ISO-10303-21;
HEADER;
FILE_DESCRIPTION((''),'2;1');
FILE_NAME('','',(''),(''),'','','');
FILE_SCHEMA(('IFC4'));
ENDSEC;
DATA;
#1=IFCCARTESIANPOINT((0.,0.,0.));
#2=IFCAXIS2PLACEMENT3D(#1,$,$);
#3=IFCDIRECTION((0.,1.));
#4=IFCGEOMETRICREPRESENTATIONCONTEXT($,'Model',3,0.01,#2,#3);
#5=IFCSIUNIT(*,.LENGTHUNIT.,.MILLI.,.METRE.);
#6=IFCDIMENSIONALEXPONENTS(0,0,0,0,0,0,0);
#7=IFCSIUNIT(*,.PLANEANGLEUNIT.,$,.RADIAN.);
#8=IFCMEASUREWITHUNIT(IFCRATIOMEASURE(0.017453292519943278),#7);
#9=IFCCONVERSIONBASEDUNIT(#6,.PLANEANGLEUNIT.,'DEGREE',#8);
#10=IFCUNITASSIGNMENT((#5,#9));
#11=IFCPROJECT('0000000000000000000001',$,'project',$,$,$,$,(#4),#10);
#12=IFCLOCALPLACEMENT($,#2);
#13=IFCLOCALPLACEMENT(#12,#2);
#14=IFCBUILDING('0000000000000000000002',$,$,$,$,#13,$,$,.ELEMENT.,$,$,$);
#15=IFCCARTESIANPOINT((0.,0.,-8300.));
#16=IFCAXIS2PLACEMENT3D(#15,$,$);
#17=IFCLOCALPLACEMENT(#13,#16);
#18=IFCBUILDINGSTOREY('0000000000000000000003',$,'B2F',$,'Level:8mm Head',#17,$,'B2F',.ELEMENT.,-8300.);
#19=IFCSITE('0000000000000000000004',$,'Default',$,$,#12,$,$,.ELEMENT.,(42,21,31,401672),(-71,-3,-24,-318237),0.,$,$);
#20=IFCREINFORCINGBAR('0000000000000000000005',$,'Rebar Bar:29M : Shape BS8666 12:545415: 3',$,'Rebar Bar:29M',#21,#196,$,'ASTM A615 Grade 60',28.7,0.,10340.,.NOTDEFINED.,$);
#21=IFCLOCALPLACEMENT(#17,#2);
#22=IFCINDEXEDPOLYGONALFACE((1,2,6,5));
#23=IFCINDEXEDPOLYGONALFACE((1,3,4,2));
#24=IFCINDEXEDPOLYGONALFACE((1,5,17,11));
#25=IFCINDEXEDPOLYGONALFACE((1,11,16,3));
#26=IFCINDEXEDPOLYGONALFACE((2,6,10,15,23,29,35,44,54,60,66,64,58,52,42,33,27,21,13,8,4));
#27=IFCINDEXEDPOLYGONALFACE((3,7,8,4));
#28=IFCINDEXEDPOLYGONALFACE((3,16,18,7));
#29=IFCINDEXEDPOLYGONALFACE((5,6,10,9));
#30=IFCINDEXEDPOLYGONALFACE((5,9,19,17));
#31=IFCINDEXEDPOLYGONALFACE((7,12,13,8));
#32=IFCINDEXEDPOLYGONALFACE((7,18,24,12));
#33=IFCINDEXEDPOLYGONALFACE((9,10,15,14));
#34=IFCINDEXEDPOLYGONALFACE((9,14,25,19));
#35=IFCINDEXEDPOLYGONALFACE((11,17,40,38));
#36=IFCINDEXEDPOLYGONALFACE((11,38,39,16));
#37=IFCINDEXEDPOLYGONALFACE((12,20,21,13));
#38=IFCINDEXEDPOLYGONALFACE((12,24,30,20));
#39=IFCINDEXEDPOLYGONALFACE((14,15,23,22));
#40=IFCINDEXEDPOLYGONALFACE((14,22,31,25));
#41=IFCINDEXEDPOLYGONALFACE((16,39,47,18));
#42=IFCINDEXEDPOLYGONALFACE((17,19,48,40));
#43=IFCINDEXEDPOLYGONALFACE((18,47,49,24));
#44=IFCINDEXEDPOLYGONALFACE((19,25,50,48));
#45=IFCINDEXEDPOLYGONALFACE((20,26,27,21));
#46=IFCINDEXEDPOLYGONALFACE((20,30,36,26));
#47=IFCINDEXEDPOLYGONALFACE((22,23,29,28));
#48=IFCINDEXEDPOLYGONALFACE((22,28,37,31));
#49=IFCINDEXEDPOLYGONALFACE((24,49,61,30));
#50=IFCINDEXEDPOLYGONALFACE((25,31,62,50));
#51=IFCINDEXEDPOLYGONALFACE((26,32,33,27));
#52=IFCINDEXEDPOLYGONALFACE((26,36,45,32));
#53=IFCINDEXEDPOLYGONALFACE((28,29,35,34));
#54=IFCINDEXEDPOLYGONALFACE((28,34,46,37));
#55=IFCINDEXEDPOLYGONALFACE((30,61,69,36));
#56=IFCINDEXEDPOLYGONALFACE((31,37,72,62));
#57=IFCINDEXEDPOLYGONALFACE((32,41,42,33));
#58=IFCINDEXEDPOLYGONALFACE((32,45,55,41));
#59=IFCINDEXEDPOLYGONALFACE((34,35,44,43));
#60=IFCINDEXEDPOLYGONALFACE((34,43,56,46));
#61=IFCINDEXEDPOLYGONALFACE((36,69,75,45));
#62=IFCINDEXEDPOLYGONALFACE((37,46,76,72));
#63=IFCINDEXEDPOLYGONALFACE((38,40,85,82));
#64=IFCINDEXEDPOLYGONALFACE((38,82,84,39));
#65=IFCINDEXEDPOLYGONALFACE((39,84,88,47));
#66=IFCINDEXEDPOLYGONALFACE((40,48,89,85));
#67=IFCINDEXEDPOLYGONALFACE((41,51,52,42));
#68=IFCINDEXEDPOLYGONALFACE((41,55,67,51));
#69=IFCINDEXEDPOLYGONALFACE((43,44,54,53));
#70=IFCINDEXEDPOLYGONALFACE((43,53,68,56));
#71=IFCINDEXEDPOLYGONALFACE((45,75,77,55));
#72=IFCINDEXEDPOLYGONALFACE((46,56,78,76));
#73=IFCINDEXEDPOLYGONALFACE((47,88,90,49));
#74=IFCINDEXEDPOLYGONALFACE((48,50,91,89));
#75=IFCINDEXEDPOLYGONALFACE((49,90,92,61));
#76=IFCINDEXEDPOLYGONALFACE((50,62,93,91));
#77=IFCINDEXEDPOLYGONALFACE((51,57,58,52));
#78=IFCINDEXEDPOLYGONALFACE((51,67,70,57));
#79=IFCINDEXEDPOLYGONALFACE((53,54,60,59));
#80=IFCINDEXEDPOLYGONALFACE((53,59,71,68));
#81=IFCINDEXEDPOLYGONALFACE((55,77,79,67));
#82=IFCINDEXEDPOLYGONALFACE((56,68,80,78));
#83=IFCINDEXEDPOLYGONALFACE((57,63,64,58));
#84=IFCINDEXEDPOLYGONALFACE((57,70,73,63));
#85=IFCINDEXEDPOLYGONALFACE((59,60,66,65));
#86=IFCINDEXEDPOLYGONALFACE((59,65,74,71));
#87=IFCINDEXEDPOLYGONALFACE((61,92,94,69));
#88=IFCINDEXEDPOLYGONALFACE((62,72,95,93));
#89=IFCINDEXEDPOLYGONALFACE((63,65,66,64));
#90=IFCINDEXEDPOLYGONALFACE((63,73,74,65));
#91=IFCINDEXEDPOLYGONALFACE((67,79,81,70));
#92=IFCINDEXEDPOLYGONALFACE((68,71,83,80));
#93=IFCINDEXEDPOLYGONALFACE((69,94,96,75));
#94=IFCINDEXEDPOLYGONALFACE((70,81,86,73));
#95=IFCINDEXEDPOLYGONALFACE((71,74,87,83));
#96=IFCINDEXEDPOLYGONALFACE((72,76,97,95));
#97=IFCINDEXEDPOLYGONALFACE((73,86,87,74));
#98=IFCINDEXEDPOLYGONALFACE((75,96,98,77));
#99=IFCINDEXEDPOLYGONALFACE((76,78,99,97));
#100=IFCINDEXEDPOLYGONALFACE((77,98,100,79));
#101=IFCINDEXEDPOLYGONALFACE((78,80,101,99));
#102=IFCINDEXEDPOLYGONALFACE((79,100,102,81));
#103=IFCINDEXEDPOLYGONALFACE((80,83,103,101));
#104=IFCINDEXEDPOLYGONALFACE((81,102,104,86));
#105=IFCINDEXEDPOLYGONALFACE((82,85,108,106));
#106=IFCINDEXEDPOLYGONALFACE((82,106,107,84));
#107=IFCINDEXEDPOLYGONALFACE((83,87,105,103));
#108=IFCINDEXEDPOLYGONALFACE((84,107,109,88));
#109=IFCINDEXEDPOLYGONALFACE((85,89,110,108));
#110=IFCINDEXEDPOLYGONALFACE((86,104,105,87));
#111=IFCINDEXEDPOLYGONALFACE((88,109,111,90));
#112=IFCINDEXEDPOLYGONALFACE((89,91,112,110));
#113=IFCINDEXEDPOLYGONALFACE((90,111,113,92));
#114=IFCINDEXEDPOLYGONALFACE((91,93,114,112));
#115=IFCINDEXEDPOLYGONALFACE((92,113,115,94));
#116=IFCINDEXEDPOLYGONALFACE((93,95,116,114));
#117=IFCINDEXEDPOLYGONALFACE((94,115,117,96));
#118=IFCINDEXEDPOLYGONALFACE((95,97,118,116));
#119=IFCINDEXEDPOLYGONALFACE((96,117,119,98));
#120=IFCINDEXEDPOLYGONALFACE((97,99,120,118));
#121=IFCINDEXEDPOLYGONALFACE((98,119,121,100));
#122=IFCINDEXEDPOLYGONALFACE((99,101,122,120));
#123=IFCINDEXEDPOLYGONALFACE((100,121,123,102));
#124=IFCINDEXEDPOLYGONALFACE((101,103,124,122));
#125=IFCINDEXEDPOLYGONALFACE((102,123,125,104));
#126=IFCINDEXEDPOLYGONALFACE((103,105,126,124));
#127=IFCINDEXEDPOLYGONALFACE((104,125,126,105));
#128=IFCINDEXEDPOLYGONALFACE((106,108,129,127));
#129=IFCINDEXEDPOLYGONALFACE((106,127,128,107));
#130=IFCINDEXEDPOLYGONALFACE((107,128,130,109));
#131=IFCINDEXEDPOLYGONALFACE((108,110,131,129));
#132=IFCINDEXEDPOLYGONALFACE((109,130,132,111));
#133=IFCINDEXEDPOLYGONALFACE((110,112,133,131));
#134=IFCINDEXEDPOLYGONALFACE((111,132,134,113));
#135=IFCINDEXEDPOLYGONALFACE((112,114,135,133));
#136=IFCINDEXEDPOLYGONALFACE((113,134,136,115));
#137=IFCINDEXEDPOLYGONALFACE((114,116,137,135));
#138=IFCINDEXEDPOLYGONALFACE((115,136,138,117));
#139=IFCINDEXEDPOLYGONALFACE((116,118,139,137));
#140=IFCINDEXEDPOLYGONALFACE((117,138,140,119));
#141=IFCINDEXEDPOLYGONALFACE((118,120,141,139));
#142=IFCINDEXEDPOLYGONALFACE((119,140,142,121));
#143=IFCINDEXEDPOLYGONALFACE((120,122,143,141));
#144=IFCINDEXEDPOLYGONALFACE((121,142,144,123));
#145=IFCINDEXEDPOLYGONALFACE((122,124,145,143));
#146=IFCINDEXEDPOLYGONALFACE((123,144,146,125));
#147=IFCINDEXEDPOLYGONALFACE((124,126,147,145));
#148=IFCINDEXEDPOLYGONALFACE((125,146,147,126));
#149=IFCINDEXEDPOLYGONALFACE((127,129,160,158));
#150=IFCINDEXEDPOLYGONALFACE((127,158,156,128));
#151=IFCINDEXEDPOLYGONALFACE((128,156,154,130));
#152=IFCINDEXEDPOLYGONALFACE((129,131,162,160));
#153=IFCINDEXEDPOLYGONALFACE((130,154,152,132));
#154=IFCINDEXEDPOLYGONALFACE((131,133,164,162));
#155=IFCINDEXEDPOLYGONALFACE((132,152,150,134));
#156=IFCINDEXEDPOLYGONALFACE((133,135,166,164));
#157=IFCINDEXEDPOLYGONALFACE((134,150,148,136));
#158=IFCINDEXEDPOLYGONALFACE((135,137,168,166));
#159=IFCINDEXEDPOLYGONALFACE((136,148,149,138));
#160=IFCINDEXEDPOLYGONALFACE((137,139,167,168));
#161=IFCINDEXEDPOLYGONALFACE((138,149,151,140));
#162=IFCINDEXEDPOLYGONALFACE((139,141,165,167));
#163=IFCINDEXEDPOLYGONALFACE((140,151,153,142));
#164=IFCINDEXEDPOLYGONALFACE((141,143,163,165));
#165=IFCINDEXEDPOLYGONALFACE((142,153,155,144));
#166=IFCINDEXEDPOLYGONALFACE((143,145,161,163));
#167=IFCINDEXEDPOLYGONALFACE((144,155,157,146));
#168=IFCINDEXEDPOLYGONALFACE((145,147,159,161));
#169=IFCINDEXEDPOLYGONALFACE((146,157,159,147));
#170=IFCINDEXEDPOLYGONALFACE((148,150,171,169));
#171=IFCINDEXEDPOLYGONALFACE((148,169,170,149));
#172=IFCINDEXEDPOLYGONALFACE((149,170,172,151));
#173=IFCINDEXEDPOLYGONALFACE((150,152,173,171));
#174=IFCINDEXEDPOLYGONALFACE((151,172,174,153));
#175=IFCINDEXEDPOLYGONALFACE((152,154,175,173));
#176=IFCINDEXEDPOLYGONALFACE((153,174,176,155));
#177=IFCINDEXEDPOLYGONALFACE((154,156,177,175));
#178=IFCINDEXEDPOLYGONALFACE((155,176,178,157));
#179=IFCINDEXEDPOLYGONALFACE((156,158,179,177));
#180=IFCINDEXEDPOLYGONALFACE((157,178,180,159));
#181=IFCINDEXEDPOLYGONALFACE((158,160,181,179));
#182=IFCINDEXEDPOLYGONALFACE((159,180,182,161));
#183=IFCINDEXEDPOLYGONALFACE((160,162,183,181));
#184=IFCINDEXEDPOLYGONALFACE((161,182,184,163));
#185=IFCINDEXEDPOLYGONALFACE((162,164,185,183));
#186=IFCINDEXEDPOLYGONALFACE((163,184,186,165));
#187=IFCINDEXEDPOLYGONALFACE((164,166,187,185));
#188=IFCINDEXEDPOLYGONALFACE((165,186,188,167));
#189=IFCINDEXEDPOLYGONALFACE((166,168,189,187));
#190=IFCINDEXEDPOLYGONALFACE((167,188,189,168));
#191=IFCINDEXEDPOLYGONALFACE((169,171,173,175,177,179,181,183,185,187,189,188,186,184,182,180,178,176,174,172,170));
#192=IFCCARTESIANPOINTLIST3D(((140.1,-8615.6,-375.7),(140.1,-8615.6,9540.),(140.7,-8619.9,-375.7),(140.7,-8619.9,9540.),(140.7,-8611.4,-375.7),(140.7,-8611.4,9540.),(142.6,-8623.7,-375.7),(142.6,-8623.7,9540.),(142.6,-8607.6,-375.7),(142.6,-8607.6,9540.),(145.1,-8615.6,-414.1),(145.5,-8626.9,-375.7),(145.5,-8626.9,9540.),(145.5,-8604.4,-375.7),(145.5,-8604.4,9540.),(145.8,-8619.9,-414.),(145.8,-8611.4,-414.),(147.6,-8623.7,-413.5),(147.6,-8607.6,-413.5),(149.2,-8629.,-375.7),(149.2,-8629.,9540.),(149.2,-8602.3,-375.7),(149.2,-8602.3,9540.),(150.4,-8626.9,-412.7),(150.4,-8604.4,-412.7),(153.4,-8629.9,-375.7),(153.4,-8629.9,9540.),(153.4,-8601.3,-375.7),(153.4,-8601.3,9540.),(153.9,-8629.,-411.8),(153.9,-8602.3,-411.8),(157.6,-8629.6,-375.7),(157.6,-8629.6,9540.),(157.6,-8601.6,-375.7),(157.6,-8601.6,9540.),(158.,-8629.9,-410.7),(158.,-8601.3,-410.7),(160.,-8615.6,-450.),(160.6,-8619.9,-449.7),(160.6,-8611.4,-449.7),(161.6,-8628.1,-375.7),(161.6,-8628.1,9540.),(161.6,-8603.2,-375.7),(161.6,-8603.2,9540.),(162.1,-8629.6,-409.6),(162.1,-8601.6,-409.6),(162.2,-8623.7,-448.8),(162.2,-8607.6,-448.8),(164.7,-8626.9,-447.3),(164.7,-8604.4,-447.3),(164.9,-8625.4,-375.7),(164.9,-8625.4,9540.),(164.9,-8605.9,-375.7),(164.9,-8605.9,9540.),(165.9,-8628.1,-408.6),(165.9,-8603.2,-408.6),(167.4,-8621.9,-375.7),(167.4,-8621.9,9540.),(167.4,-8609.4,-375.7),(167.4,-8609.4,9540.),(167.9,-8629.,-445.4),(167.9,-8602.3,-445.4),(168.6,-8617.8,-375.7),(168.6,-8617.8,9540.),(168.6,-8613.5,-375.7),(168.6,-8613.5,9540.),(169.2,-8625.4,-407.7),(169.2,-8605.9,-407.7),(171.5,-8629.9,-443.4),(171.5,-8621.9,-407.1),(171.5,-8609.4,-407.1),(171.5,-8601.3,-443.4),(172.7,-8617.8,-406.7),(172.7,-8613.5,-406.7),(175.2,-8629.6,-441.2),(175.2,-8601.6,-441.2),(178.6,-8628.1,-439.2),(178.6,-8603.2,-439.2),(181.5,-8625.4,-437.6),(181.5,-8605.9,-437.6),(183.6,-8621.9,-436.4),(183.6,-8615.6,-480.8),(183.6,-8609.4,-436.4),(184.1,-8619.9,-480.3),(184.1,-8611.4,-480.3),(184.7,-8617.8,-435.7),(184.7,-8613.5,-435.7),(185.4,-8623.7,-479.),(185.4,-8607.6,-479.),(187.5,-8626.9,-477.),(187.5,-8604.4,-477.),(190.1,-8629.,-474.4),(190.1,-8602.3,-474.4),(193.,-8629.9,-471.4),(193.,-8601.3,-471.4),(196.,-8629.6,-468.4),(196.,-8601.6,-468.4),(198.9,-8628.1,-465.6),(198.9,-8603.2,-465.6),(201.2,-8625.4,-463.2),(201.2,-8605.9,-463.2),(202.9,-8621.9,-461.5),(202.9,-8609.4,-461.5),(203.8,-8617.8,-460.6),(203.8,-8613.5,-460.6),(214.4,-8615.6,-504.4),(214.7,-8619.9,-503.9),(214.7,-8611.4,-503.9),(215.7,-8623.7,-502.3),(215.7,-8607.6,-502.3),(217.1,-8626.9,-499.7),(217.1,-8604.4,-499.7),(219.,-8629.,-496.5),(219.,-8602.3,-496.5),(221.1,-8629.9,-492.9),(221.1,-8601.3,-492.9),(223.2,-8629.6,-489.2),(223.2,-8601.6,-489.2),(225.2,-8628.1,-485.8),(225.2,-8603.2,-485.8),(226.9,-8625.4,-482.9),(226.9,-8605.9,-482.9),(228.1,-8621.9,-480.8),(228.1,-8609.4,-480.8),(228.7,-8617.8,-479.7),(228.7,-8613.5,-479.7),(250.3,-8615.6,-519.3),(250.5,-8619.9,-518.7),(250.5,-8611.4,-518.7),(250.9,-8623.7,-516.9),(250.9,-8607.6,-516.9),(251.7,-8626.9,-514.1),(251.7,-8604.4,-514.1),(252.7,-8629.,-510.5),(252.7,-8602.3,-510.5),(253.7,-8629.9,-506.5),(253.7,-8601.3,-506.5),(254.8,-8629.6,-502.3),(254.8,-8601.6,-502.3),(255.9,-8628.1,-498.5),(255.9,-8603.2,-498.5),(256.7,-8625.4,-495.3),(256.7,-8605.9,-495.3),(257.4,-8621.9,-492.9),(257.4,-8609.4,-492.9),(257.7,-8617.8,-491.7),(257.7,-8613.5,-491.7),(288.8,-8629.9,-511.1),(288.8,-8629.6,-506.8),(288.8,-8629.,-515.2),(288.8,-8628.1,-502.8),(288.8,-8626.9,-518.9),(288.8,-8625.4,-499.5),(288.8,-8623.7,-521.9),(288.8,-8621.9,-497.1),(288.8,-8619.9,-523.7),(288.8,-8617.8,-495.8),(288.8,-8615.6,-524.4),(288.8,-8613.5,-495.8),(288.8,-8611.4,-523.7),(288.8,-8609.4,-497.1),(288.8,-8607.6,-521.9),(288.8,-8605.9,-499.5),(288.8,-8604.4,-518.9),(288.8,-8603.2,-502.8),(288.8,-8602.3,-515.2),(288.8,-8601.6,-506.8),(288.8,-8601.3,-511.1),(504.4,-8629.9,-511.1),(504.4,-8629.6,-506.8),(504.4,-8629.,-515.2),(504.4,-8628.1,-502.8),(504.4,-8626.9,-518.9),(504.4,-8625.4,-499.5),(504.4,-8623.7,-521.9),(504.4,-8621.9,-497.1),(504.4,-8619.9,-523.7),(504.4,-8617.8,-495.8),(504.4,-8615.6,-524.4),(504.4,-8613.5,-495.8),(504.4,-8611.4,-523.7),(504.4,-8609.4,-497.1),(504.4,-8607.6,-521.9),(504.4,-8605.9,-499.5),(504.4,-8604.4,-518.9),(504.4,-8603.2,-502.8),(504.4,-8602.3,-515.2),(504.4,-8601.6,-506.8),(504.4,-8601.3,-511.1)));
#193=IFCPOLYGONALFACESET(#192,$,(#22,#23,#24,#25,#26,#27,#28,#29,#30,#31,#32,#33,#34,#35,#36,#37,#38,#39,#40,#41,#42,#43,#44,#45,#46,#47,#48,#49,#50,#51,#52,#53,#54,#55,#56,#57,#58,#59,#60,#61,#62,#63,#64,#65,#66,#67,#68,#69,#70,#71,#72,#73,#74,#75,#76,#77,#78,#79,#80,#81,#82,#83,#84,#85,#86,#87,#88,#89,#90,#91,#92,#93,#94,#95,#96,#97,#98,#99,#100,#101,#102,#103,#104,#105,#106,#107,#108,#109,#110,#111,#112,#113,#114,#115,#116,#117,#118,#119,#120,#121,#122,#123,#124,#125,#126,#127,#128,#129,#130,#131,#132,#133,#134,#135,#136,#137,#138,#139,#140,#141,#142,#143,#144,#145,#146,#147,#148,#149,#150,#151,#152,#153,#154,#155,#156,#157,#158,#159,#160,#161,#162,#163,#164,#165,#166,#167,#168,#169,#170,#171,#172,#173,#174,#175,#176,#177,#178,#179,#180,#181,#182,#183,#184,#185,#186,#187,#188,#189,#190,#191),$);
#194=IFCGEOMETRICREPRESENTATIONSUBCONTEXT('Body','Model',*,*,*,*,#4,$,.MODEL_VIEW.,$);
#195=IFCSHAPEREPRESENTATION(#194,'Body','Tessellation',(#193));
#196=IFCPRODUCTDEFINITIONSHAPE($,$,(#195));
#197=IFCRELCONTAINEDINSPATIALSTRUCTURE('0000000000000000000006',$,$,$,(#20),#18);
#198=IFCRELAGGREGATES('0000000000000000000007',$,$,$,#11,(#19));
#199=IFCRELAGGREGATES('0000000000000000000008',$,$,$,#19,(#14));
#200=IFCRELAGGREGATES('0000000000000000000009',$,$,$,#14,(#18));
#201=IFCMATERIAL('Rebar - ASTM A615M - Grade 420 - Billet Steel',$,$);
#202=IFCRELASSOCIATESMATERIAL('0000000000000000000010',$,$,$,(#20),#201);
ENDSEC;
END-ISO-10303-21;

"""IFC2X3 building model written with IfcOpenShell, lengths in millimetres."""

from ifc_helpers import new_model, entity, si_unit, converted_unit, direction, frame, origin, place, context, subcontext, project, spatial, material, element, save


model = new_model("IFC2X3")

# Units and contexts
model_context = context("Model", 3, precision=0.01, world=origin(), true_north=direction((0.0, 1.0)))
body_context = subcontext(model_context, "Body", "Model", "MODEL_VIEW")
ifc_project = project(units=[si_unit("LENGTHUNIT", "METRE", prefix="MILLI"), converted_unit("PLANEANGLEUNIT", "DEGREE", entity("IfcRatioMeasure", 0.017453292519943278), si_unit("PLANEANGLEUNIT", "RADIAN"), dimensions=[0, 0, 0, 0, 0, 0, 0])], contexts=[model_context])

# Site, building, storey
site_placement = place(None, origin())
site = spatial("IfcSite", under=ifc_project, at=site_placement, Name="Default", CompositionType="ELEMENT", RefLatitude=(42, 21, 31, 401672), RefLongitude=(-71, -3, -24, -318237), RefElevation=0.0)
building_placement = place(site_placement, origin())
building = spatial("IfcBuilding", under=site, at=building_placement, CompositionType="ELEMENT")
storey_placement = place(building_placement, frame((0.0, 0.0, -8300.0)))
storey = spatial("IfcBuildingStorey", under=building, at=storey_placement, Name="B2F", ObjectType="Level:8mm Head", LongName="B2F", CompositionType="ELEMENT", Elevation=-8300.0)

# Reinforcing bar
ifc_material_1 = material(Name="Rebar - ASTM A615M - Grade 420 - Billet Steel")
reinforcing_bar_1_placement = place(storey_placement, origin())
element("IfcReinforcingBar", 1, at=reinforcing_bar_1_placement, inside=storey, material=ifc_material_1, Name="Rebar Bar:29M : Shape BS8666 12:545415: 3", SteelGrade="ASTM A615 Grade 60", ObjectType="Rebar Bar:29M", BarLength=10340.0, BarRole="NOTDEFINED", CrossSectionArea=0.0, NominalDiameter=28.7, context=body_context, shape_type="AdvancedSweptSolid", body=[
    entity("IfcSweptDiskSolid", entity("IfcCompositeCurve", [entity("IfcCompositeCurveSegment", "CONTINUOUS", True, entity("IfcPolyline", [entity("IfcCartesianPoint", [154.4, -8615.6, 9540.0]), entity("IfcCartesianPoint", [154.4, -8615.6, -375.7])])), entity("IfcCompositeCurveSegment", "CONTINUOUS", True, entity("IfcTrimmedCurve", entity("IfcCircle", entity("IfcAxis2Placement3D", entity("IfcCartesianPoint", [288.8, -8615.6, -375.7]), entity("IfcDirection", [0.0, -1.0, 0.0]), entity("IfcDirection", [0.0, 0.0, -1.0])), 134.3), [entity("IfcParameterValue", 270.0)], [entity("IfcParameterValue", 360.0)], True, "PARAMETER")), entity("IfcCompositeCurveSegment", "CONTINUOUS", True, entity("IfcPolyline", [entity("IfcCartesianPoint", [288.8, -8615.6, -510.0]), entity("IfcCartesianPoint", [504.4, -8615.6, -510.0])]))], False), 14.3, None, 0.0, 92.0),
])

save(model, "model.ifc")
